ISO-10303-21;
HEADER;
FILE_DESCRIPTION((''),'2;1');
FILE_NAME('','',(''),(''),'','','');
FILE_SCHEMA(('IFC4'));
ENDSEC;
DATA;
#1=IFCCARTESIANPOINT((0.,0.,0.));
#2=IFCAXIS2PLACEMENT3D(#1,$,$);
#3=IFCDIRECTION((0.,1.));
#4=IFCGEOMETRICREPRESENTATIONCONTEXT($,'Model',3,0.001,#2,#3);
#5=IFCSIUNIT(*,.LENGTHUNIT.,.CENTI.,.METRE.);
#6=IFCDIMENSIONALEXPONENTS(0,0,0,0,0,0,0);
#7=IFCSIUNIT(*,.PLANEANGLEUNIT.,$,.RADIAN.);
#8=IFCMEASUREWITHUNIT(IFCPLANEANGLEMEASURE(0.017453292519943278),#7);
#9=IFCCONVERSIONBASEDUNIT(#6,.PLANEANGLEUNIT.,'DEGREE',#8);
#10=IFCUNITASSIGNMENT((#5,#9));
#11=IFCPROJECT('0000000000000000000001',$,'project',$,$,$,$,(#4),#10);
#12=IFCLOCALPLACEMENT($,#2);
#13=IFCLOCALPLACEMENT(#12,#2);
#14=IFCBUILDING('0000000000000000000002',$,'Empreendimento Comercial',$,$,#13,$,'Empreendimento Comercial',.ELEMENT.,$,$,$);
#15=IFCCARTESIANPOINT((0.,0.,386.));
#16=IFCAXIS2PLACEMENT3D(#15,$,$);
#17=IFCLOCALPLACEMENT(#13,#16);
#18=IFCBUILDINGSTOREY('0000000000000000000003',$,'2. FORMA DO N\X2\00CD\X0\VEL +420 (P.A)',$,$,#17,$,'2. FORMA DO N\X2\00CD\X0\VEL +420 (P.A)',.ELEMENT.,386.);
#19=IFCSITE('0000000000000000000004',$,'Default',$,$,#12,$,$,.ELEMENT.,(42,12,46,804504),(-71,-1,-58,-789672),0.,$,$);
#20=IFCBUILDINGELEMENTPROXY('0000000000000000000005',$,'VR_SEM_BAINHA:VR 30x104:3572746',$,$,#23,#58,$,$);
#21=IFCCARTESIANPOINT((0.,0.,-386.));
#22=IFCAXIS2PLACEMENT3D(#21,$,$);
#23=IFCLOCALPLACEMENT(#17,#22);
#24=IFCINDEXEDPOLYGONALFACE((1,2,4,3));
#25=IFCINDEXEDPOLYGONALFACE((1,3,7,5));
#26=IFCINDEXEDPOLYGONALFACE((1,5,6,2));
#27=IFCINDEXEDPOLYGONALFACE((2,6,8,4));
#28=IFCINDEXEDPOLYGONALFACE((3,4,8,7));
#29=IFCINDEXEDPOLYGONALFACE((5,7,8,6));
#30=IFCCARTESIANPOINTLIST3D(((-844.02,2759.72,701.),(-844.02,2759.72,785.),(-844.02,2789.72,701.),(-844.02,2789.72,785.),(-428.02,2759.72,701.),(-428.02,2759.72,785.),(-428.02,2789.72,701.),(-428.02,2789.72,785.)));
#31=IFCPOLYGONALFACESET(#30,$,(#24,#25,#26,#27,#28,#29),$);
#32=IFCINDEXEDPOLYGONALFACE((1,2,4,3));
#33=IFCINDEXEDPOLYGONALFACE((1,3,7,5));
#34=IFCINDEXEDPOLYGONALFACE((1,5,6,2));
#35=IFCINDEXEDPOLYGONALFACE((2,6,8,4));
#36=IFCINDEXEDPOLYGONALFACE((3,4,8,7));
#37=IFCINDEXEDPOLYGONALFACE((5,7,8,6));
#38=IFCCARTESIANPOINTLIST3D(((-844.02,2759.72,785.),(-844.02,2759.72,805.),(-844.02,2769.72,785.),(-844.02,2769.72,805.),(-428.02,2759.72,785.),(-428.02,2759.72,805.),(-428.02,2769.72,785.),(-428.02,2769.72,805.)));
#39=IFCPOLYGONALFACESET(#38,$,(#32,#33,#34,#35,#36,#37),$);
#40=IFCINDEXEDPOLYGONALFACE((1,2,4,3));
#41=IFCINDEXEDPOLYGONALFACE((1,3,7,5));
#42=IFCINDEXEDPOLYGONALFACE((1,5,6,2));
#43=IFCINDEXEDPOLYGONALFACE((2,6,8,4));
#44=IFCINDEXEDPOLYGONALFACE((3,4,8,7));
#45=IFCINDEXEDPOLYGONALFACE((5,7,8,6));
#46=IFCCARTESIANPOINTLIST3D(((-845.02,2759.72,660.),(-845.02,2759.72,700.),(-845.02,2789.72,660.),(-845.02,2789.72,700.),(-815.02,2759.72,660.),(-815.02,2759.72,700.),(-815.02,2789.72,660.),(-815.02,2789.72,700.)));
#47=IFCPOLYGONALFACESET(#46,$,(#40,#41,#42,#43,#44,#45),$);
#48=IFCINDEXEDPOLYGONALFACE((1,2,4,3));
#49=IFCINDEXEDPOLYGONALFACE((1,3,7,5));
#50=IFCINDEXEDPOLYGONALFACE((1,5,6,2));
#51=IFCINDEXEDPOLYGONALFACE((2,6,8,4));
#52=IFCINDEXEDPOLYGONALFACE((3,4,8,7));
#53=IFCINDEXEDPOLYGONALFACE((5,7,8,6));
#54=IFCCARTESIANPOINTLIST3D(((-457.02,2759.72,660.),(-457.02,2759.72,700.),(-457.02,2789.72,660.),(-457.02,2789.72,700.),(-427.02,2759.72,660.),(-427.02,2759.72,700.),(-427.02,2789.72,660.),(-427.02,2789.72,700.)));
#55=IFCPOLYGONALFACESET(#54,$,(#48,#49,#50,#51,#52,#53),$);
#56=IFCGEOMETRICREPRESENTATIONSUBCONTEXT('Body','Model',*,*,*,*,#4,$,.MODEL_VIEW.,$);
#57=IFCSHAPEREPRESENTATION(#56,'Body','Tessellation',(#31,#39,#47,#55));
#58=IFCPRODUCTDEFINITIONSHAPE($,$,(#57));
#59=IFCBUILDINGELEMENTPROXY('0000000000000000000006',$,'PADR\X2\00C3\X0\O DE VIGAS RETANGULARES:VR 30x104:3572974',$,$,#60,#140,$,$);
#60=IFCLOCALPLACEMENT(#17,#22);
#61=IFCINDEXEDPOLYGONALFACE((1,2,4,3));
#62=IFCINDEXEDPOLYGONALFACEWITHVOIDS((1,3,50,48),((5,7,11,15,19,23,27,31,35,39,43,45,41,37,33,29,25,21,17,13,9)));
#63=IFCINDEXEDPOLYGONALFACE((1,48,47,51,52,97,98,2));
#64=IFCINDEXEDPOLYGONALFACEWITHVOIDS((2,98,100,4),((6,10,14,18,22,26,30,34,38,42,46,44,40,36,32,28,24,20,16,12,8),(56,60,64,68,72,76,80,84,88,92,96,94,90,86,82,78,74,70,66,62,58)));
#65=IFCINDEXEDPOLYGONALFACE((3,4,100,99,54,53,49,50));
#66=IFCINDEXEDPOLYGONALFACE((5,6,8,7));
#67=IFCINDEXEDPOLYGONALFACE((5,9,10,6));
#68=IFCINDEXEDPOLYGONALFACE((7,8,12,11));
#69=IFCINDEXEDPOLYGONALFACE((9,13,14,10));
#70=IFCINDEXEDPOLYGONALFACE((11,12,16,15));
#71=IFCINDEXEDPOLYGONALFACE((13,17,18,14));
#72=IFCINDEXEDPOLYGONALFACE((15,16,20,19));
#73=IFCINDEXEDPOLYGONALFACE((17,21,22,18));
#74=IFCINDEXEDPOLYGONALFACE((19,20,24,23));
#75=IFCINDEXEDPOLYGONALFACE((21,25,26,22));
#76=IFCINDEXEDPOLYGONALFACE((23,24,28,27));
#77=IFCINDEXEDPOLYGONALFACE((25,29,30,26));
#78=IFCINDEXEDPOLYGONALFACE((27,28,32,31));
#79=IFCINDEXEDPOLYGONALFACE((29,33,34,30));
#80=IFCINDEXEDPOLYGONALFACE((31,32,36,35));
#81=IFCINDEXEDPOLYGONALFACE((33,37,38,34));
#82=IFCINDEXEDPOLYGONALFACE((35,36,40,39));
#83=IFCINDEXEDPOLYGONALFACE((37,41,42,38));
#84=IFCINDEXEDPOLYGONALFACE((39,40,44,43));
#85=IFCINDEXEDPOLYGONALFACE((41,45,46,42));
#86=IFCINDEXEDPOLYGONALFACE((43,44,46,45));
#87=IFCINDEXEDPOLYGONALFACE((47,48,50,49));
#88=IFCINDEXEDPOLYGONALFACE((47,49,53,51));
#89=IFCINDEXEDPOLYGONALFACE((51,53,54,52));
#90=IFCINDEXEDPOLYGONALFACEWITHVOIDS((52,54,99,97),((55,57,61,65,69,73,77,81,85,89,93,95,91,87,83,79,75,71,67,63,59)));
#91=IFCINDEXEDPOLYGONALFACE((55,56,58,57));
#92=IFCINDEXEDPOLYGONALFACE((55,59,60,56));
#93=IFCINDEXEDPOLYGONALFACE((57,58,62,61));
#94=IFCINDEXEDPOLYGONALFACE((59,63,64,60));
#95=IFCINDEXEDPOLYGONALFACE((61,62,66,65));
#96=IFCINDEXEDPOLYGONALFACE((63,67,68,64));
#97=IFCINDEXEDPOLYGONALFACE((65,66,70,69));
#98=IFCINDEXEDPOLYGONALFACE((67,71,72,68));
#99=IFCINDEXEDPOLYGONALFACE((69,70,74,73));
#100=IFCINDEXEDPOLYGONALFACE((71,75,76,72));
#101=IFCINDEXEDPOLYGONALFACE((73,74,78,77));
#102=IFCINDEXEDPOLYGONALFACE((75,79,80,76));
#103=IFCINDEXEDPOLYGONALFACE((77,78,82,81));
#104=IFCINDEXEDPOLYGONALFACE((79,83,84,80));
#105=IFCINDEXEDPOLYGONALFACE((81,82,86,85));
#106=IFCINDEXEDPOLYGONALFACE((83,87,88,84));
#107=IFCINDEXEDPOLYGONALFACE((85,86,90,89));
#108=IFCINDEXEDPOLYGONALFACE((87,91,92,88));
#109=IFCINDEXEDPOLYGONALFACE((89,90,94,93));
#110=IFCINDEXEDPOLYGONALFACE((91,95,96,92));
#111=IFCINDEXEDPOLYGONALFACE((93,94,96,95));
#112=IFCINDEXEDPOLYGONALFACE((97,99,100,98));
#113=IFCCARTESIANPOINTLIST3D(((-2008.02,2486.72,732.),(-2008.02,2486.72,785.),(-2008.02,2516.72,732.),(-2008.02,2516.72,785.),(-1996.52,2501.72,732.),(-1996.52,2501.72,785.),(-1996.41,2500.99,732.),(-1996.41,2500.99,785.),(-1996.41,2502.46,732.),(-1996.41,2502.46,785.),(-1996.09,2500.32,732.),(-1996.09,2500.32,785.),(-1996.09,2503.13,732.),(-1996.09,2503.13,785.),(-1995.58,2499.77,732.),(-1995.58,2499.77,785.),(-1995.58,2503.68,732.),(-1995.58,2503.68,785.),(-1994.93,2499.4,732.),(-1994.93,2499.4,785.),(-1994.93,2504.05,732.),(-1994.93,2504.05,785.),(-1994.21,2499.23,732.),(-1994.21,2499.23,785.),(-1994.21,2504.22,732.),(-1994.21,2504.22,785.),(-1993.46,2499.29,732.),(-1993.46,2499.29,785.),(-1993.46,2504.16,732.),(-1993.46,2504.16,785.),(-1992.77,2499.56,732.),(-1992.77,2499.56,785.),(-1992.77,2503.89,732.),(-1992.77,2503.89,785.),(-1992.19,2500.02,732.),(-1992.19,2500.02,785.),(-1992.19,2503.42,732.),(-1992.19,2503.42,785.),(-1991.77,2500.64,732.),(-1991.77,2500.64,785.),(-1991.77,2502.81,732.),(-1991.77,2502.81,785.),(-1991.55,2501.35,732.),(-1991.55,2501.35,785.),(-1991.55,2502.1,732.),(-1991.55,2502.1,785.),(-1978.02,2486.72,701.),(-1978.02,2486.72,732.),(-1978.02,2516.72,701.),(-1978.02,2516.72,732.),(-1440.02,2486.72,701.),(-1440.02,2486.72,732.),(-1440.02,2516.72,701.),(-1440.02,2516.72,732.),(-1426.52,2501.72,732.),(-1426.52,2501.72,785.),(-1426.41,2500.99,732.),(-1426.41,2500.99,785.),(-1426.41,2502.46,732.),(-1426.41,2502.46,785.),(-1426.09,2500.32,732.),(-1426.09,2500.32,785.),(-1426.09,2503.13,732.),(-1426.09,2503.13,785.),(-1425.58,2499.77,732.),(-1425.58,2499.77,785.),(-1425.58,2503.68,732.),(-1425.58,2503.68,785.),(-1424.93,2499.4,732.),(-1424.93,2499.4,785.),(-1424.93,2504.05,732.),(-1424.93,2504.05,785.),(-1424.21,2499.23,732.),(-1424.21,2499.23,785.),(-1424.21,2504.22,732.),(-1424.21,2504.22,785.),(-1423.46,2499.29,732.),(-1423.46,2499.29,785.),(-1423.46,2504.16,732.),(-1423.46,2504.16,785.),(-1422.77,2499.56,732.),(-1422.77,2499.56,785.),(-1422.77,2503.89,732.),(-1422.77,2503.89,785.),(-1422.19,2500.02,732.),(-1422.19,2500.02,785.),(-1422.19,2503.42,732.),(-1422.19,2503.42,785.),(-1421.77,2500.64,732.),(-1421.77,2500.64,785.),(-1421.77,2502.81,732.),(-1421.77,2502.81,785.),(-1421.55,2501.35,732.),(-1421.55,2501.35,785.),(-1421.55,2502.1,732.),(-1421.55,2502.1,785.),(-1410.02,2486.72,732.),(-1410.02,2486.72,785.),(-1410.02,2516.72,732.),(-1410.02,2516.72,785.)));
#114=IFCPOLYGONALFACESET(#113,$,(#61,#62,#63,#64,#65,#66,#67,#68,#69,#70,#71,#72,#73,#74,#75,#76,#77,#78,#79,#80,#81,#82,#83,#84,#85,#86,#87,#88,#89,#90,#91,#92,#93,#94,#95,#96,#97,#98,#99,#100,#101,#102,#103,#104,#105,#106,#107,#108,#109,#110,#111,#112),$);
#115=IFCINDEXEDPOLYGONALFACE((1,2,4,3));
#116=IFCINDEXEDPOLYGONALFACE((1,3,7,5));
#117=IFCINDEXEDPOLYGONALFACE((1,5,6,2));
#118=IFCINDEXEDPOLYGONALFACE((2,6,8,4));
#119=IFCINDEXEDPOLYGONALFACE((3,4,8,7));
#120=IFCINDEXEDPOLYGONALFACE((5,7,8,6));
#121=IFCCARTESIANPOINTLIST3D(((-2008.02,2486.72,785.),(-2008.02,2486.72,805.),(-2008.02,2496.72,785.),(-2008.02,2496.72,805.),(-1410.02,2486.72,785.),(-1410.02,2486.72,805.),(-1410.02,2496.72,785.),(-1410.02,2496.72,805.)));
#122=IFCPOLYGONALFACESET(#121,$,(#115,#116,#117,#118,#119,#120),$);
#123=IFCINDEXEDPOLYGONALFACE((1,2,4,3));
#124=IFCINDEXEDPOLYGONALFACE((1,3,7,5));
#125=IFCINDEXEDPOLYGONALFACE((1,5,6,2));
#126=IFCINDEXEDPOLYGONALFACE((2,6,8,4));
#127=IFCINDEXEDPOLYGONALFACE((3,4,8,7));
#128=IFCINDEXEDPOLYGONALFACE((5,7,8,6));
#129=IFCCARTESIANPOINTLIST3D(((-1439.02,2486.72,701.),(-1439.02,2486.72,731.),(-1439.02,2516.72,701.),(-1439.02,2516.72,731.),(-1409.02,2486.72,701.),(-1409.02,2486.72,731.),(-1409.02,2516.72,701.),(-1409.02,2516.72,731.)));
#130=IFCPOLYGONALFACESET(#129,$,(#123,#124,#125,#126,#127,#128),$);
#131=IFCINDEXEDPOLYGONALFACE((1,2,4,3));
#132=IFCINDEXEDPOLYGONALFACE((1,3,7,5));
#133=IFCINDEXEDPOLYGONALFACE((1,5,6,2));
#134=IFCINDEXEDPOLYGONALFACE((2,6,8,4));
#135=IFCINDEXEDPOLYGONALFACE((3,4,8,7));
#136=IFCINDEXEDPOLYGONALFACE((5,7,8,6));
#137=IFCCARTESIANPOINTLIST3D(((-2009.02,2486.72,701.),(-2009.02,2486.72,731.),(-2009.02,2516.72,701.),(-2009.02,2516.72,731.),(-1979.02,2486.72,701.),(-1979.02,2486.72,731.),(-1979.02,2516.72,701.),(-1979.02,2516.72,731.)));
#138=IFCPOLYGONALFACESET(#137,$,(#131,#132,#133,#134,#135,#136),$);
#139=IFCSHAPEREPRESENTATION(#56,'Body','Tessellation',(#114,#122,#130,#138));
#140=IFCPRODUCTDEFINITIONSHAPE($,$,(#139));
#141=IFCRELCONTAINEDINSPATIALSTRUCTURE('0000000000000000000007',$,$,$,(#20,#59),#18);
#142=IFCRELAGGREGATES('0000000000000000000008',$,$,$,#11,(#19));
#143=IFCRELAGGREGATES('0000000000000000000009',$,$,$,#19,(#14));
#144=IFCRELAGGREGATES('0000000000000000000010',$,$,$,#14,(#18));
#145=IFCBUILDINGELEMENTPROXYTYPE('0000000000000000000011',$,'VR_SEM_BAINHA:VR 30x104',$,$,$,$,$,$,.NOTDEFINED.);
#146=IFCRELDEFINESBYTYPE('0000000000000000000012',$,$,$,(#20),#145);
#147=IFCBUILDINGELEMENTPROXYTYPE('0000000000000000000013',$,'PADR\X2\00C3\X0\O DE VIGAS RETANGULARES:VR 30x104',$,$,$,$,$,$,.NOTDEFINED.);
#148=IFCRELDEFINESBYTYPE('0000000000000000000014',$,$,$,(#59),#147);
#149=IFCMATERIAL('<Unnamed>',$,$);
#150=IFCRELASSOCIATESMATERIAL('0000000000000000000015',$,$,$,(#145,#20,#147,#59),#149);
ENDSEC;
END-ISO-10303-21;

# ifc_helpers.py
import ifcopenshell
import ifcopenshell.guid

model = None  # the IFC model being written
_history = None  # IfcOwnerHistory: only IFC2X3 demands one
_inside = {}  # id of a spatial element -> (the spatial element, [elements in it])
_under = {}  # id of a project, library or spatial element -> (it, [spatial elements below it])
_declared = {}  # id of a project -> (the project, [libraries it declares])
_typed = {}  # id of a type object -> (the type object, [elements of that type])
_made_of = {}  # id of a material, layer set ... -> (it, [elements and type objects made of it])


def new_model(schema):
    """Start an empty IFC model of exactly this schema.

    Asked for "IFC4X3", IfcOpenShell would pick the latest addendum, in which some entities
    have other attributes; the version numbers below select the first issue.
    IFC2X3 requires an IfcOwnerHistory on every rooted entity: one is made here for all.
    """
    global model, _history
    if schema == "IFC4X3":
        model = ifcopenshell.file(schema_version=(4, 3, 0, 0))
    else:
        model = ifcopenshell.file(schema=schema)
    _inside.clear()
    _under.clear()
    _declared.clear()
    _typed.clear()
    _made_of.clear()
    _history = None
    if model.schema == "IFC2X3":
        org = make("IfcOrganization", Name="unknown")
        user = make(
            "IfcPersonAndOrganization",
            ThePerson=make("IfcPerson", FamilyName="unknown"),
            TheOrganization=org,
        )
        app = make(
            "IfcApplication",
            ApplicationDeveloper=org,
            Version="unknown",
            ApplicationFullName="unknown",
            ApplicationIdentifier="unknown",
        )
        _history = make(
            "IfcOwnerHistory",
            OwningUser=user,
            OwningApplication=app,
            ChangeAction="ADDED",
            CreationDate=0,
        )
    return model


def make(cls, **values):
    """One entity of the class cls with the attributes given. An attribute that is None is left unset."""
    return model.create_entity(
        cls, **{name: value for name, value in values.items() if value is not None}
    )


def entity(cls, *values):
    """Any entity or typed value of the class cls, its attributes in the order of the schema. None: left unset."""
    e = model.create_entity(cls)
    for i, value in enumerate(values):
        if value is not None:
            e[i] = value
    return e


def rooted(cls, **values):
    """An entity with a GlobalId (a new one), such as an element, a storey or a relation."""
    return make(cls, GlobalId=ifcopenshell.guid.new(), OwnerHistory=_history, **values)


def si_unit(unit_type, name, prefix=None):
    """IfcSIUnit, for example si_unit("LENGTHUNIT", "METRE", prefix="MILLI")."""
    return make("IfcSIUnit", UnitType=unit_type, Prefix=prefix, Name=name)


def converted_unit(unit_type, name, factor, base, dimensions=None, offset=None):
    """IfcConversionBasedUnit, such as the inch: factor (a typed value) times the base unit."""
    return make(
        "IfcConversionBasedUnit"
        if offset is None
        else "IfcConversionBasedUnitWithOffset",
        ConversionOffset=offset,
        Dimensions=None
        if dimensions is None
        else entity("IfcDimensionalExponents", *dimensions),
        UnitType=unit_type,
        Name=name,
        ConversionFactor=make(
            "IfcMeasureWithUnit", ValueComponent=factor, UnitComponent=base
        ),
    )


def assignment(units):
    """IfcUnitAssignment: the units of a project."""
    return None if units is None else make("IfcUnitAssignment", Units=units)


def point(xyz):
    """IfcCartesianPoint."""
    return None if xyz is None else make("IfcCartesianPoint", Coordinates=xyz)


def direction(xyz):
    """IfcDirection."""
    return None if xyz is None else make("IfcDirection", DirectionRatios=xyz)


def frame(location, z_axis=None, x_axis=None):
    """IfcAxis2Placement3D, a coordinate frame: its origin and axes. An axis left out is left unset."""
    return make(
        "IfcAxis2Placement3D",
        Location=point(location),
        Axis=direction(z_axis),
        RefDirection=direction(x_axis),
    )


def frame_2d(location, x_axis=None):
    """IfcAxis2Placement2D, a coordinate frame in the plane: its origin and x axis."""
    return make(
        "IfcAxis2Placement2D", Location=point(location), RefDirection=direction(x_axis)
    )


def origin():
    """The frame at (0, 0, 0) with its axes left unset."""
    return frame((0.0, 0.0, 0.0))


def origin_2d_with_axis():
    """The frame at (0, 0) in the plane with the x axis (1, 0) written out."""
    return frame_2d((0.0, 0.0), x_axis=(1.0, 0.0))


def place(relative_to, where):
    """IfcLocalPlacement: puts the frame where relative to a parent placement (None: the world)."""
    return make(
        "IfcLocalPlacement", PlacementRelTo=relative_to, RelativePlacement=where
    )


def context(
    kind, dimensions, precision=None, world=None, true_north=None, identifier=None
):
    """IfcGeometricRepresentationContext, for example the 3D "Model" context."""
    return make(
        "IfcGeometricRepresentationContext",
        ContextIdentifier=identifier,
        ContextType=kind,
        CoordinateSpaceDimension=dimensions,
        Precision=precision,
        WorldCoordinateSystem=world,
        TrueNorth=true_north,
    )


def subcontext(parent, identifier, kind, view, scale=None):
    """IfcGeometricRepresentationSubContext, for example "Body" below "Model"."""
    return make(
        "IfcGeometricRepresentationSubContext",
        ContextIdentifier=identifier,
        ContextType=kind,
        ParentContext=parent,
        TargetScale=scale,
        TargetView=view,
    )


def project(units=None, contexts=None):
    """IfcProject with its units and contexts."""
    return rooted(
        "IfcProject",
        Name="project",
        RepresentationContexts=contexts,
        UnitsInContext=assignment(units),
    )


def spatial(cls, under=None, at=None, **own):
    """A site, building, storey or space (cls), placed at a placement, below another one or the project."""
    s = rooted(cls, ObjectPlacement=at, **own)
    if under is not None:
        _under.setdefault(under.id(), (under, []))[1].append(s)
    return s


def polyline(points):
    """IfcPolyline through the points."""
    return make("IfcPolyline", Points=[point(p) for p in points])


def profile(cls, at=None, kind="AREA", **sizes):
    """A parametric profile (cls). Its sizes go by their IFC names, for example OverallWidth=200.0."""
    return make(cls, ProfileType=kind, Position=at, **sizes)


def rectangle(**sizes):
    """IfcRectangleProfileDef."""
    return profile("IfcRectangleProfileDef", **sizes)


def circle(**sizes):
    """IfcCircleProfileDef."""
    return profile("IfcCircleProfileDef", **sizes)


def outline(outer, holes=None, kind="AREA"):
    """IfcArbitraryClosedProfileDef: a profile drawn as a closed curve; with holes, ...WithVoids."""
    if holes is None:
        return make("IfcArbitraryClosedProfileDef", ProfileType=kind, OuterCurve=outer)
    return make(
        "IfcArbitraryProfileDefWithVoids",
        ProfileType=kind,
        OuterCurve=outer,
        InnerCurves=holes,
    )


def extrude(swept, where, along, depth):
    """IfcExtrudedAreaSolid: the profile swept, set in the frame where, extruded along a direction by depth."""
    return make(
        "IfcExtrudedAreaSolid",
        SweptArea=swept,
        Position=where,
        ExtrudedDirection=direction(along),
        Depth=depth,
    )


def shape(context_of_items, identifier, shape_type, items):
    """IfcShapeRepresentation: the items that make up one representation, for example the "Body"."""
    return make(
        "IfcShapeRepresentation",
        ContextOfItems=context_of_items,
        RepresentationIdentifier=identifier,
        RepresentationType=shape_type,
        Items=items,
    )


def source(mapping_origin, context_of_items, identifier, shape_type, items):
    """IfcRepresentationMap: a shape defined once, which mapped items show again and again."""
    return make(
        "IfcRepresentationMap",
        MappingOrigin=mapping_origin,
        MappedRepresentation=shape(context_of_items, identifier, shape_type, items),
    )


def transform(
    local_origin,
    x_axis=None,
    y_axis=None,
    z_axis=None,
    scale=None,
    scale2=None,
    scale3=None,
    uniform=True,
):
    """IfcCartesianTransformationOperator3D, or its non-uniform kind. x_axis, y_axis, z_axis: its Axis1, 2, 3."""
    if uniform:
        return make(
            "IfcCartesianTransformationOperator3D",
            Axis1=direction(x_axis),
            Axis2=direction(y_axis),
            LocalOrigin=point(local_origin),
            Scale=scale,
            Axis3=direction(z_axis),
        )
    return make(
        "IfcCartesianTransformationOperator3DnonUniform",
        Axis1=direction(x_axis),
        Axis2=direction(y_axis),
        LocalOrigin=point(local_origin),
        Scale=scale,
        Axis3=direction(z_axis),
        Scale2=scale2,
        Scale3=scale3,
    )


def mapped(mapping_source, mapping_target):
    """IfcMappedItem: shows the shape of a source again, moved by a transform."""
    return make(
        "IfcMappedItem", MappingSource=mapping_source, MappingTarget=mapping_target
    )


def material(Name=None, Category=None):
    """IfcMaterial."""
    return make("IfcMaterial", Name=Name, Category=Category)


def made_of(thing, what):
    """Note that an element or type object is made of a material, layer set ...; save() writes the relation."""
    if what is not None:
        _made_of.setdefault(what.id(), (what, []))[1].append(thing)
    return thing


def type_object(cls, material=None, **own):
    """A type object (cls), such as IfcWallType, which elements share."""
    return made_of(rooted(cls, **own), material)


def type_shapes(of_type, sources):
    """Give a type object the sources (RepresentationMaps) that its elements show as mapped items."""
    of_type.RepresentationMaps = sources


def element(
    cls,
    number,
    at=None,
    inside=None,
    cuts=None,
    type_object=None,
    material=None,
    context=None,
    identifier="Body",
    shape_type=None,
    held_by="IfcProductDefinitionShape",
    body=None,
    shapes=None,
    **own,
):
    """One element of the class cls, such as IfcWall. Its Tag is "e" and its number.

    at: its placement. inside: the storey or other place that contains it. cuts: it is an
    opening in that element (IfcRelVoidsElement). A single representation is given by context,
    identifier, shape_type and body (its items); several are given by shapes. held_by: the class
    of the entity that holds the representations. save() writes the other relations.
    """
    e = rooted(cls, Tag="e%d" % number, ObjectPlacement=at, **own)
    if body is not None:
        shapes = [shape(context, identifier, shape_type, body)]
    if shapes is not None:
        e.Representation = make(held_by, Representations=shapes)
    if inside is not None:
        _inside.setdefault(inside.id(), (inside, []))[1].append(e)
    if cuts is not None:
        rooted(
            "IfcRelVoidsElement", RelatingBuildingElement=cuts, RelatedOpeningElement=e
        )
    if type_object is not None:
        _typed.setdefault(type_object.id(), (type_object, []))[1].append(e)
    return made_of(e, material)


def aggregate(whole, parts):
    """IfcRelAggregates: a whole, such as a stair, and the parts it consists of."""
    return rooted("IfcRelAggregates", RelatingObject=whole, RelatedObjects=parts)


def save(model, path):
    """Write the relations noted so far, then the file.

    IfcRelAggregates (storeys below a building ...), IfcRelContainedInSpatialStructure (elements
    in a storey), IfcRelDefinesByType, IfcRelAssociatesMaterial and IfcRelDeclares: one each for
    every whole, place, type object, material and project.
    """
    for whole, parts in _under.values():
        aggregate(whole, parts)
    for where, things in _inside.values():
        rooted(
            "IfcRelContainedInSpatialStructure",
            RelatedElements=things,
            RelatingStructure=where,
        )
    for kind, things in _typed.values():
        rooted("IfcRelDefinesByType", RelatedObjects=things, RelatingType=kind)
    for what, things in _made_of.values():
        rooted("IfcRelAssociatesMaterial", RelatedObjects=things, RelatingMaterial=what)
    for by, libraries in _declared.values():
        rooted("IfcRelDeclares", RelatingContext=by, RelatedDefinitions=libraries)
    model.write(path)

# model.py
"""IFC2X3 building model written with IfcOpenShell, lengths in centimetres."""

from ifc_helpers import new_model, entity, si_unit, converted_unit, direction, frame, frame_2d, origin, origin_2d_with_axis, place, context, subcontext, project, spatial, polyline, rectangle, circle, outline, extrude, source, transform, mapped, material, type_object, type_shapes, element, save


model = new_model("IFC2X3")

# Units and contexts
model_context = context("Model", 3, precision=0.001, world=origin(), true_north=direction((0.0, 1.0)))
body_context = subcontext(model_context, "Body", "Model", "MODEL_VIEW")
ifc_project = project(units=[si_unit("LENGTHUNIT", "METRE", prefix="CENTI"), converted_unit("PLANEANGLEUNIT", "DEGREE", entity("IfcPlaneAngleMeasure", 0.017453292519943278), si_unit("PLANEANGLEUNIT", "RADIAN"), dimensions=[0, 0, 0, 0, 0, 0, 0])], contexts=[model_context])

# Site, building, storey
site_placement = place(None, origin())
site = spatial("IfcSite", under=ifc_project, at=site_placement, Name="Default", CompositionType="ELEMENT", RefLatitude=(42, 12, 46, 804504), RefLongitude=(-71, -1, -58, -789672), RefElevation=0.0)
building_placement = place(site_placement, origin())
building = spatial("IfcBuilding", under=site, at=building_placement, Name="Empreendimento Comercial", LongName="Empreendimento Comercial", CompositionType="ELEMENT")
storey_placement = place(building_placement, frame((0.0, 0.0, 386.0)))
storey = spatial("IfcBuildingStorey", under=building, at=storey_placement, Name="2. FORMA DO NÍVEL +420 (P.A)", LongName="2. FORMA DO NÍVEL +420 (P.A)", CompositionType="ELEMENT", Elevation=386.0)

# Building element proxy
ifc_material_1 = material(Name="<Unnamed>")
building_element_proxy_type_1 = type_object("IfcBuildingElementProxyType", Name="VR_SEM_BAINHA:VR 30x104", PredefinedType="NOTDEFINED", material=ifc_material_1)
shared_shape_1 = source(origin(), body_context, "Body", "SweptSolid", [
    extrude(rectangle(XDim=30.0, YDim=416.0, at=frame_2d((5.0, 8.0), x_axis=(1.0, 0.0))), frame((-628.02, 2769.72, 701.0), z_axis=(0.0, 0.0, 1.0), x_axis=(0.0, 1.0, 0.0)), (0.0, 0.0, 1.0), 84.0),
    extrude(rectangle(XDim=10.0, YDim=416.0, at=frame_2d((0.0, 0.0), x_axis=(1.0, 0.0))), frame((-636.02, 2764.72, 785.0), z_axis=(0.0, 0.0, 1.0), x_axis=(0.0, 1.0, 0.0)), (0.0, 0.0, 1.0), 20.0),
    extrude(rectangle(XDim=30.0, YDim=30.0, at=frame_2d((0.0, 0.0), x_axis=(1.0, 0.0))), frame((-830.02, 2774.72, 660.0), z_axis=(0.0, 0.0, 1.0), x_axis=(-1.0, 0.0, 0.0)), (0.0, 0.0, 1.0), 40.0),
    extrude(rectangle(XDim=30.0, YDim=30.0, at=frame_2d((0.0, 0.0), x_axis=(1.0, 0.0))), frame((-442.02, 2774.72, 660.0), z_axis=(0.0, 0.0, 1.0), x_axis=(-1.0, 0.0, 0.0)), (0.0, 0.0, 1.0), 40.0),
])
type_shapes(building_element_proxy_type_1, [shared_shape_1])
proxy_1_placement = place(storey_placement, frame((0.0, 0.0, -386.0)))
element("IfcBuildingElementProxy", 1, at=proxy_1_placement, inside=storey, type_object=building_element_proxy_type_1, material=ifc_material_1, Name="VR_SEM_BAINHA:VR 30x104:3572746", context=body_context, shape_type="MappedRepresentation", body=[
    mapped(shared_shape_1, transform((0.0, 0.0, 0.0), scale=1.0)),
])

# Building element proxy, openings
building_element_proxy_type_2 = type_object("IfcBuildingElementProxyType", Name="PADRÃO DE VIGAS RETANGULARES:VR 30x104", PredefinedType="NOTDEFINED", material=ifc_material_1)
shared_shape_2 = source(origin(), body_context, "Body", "SweptSolid", [
    extrude(outline(polyline([(-47.5, -299.0), (5.5, -299.0), (5.5, -269.0), (36.5, -269.0), (36.5, 269.0), (5.5, 269.0), (5.5, 299.0), (-47.5, 299.0), (-47.5, -299.0)])), frame((-1709.02, 2486.72, 737.5), z_axis=(0.0, 1.0, 0.0), x_axis=(0.0, 0.0, -1.0)), (0.0, 0.0, 1.0), 30.0),
    extrude(rectangle(XDim=598.0, YDim=10.0, at=origin_2d_with_axis()), frame((-1709.02, 2491.72, 785.0)), (0.0, 0.0, 1.0), 20.0),
    extrude(rectangle(XDim=30.0, YDim=30.0, at=frame_2d((0.0, 0.0), x_axis=(1.0, 0.0))), frame((-1424.02, 2501.72, 701.0), z_axis=(0.0, 0.0, 1.0), x_axis=(0.0, -1.0, 0.0)), (0.0, 0.0, 1.0), 30.0),
    extrude(rectangle(XDim=30.0, YDim=30.0, at=frame_2d((0.0, 0.0), x_axis=(1.0, 0.0))), frame((-1994.02, 2501.72, 701.0), z_axis=(0.0, 0.0, 1.0), x_axis=(0.0, -1.0, 0.0)), (0.0, 0.0, 1.0), 30.0),
])
type_shapes(building_element_proxy_type_2, [shared_shape_2])
proxy_2_placement = place(storey_placement, frame((0.0, 0.0, -386.0)))
proxy_2 = element("IfcBuildingElementProxy", 2, at=proxy_2_placement, inside=storey, type_object=building_element_proxy_type_2, material=ifc_material_1, Name="PADRÃO DE VIGAS RETANGULARES:VR 30x104:3572974", context=body_context, shape_type="MappedRepresentation", body=[
    mapped(shared_shape_2, transform((0.0, 0.0, 0.0), scale=1.0)),
])
opening_1_placement = place(storey_placement, frame((0.0, 0.0, -386.0)))
element("IfcOpeningElement", 3, at=opening_1_placement, cuts=proxy_2, ObjectType="Opening", context=body_context, shape_type="SweptSolid", body=[
    extrude(circle(Radius=2.5, at=origin_2d_with_axis()), frame((-1994.02, 2501.72, 732.0), z_axis=(0.0, 0.0, 1.0), x_axis=(-1.0, 0.0, 0.0)), (0.0, 0.0, 1.0), 53.0),
])
opening_2_placement = place(storey_placement, frame((0.0, 0.0, -386.0)))
element("IfcOpeningElement", 4, at=opening_2_placement, cuts=proxy_2, ObjectType="Opening", context=body_context, shape_type="SweptSolid", body=[
    extrude(circle(Radius=2.5, at=origin_2d_with_axis()), frame((-1424.02, 2501.72, 732.0), z_axis=(0.0, 0.0, 1.0), x_axis=(-1.0, 0.0, 0.0)), (0.0, 0.0, 1.0), 53.0),
])

save(model, "model.ifc")
